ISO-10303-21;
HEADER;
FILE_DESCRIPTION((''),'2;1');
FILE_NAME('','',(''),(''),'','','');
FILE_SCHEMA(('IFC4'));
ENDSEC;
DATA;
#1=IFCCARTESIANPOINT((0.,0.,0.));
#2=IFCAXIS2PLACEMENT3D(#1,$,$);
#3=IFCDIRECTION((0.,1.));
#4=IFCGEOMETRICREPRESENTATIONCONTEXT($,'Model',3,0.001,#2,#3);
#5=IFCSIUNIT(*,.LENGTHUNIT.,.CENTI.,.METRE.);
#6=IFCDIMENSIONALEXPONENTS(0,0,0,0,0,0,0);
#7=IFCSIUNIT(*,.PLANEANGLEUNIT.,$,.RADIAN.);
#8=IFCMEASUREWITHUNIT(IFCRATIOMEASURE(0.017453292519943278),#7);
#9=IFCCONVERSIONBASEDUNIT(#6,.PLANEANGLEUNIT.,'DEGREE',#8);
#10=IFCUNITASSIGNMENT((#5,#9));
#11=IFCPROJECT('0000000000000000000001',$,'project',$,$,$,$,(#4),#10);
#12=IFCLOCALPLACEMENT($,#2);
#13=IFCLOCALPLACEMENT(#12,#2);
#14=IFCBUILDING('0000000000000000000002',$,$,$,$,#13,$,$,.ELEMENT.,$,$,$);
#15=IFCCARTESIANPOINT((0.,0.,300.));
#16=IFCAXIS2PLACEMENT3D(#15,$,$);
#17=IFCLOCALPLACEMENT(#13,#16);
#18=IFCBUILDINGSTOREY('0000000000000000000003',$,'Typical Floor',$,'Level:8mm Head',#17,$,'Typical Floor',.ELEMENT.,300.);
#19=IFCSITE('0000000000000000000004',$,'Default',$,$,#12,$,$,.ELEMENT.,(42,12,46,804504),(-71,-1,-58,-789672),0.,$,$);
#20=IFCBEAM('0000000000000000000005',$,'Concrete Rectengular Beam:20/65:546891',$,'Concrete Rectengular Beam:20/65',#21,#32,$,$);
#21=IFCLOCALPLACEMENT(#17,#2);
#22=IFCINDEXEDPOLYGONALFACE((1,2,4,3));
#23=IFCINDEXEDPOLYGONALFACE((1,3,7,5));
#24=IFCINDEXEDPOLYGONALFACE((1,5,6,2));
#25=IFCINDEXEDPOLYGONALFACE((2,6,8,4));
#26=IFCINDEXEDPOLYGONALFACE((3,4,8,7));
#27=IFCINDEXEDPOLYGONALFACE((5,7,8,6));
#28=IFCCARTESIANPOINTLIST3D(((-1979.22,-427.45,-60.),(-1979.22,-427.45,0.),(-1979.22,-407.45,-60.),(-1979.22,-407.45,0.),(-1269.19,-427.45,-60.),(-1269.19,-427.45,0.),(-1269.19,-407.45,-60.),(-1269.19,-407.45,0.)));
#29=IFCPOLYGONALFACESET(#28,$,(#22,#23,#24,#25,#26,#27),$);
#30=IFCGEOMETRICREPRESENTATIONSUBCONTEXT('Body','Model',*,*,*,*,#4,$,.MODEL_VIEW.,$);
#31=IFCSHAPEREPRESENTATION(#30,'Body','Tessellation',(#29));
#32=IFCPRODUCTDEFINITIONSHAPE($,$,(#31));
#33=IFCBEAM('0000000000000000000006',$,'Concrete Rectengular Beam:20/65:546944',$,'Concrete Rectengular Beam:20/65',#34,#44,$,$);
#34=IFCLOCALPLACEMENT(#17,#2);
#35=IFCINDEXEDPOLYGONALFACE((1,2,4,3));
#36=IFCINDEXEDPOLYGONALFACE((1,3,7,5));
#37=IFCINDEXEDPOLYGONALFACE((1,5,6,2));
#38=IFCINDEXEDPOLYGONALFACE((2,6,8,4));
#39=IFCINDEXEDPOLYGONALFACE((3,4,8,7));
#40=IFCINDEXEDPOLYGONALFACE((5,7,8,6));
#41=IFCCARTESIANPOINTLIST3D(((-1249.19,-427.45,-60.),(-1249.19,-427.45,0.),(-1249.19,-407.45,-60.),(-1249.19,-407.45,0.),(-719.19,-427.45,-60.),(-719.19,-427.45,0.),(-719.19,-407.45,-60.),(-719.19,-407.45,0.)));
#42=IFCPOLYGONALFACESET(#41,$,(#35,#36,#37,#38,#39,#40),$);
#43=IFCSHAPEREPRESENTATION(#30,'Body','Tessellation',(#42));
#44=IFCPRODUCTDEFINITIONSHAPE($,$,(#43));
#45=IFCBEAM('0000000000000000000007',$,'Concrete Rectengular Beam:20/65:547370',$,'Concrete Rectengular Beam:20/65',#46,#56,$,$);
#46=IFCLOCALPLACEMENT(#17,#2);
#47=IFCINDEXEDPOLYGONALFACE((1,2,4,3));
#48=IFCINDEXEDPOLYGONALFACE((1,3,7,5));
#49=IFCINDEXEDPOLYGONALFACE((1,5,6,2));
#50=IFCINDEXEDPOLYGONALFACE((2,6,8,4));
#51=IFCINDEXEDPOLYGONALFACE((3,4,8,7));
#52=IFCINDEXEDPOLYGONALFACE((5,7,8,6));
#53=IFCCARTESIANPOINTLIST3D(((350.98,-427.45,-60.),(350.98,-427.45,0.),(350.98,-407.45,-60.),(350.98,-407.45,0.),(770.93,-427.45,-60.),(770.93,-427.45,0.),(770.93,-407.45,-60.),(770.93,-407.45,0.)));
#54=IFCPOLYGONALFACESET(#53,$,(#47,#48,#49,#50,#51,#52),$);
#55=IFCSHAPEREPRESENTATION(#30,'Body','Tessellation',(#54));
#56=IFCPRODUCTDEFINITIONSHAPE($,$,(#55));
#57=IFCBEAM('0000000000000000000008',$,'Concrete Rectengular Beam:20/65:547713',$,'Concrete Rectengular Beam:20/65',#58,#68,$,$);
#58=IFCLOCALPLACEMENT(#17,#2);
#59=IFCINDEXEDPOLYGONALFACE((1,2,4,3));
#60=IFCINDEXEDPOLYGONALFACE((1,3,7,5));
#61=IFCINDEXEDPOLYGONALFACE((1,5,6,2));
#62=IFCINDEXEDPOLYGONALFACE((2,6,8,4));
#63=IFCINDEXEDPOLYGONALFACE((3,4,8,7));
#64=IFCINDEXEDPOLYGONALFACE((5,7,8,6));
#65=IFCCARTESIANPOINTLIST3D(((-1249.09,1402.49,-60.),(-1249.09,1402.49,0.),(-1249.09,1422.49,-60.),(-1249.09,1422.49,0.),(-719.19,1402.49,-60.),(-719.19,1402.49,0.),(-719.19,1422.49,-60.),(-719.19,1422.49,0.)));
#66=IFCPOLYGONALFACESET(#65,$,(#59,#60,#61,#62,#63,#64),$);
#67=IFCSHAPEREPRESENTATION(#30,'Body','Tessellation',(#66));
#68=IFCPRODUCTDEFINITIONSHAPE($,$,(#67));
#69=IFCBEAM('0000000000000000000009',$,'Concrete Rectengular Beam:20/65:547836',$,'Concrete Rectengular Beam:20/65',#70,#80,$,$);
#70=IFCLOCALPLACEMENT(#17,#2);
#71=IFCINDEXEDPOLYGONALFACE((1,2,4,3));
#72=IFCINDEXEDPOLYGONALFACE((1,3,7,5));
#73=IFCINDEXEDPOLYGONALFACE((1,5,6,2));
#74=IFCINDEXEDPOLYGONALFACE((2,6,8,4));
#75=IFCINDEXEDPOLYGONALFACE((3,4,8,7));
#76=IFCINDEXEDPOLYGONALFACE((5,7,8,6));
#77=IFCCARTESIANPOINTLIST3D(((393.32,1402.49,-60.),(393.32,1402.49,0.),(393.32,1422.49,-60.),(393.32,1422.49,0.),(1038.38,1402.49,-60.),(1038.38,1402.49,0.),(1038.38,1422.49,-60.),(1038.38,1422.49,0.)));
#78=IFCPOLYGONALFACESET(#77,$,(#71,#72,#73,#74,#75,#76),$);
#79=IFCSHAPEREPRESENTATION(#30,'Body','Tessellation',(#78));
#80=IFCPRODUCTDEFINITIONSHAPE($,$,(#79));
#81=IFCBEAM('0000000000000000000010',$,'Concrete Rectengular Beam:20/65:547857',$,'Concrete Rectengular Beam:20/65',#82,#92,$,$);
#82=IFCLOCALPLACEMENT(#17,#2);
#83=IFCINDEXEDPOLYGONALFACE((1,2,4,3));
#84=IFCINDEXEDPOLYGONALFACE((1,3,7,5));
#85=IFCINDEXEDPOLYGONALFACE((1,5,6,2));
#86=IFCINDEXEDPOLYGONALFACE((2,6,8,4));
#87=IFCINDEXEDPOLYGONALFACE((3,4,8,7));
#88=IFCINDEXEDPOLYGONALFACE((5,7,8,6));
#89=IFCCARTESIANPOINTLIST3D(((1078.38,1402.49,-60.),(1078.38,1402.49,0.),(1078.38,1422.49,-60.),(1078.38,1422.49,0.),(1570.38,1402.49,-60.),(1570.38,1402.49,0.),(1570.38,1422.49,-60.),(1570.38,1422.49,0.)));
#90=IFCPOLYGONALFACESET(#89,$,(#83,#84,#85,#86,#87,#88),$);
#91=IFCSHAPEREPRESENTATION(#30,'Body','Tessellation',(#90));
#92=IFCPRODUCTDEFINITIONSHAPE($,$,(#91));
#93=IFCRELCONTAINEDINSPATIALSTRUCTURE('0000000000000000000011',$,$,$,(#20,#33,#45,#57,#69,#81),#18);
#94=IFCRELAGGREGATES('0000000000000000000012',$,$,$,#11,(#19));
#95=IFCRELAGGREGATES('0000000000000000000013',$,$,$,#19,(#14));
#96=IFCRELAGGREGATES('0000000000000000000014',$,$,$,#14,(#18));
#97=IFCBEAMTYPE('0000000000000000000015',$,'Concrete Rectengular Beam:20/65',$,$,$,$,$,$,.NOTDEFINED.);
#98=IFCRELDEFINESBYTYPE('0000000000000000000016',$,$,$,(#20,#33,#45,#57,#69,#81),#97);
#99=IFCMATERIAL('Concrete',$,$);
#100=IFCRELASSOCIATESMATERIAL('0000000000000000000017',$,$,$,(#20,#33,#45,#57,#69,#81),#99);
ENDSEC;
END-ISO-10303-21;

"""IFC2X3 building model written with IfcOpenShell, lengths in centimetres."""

from ifc_helpers import new_model, entity, si_unit, converted_unit, direction, frame, frame_2d, origin, place, context, subcontext, project, spatial, rectangle, extrude, material, type_object, element, save


model = new_model("IFC2X3")

# Units and contexts
model_context = context("Model", 3, precision=0.001, world=origin(), true_north=direction((0.0, 1.0)))
body_context = subcontext(model_context, "Body", "Model", "MODEL_VIEW")
ifc_project = project(units=[si_unit("LENGTHUNIT", "METRE", prefix="CENTI"), converted_unit("PLANEANGLEUNIT", "DEGREE", entity("IfcRatioMeasure", 0.017453292519943278), si_unit("PLANEANGLEUNIT", "RADIAN"), dimensions=[0, 0, 0, 0, 0, 0, 0])], contexts=[model_context])

# Site, building, storey
site_placement = place(None, origin())
site = spatial("IfcSite", under=ifc_project, at=site_placement, Name="Default", CompositionType="ELEMENT", RefLatitude=(42, 12, 46, 804504), RefLongitude=(-71, -1, -58, -789672), RefElevation=0.0)
building_placement = place(site_placement, origin())
building = spatial("IfcBuilding", under=site, at=building_placement, CompositionType="ELEMENT")
storey_placement = place(building_placement, frame((0.0, 0.0, 300.0)))
storey = spatial("IfcBuildingStorey", under=building, at=storey_placement, Name="Typical Floor", ObjectType="Level:8mm Head", LongName="Typical Floor", CompositionType="ELEMENT", Elevation=300.0)

# Beams
ifc_material = material(Name="Concrete")
beam_type_1 = type_object("IfcBeamType", Name="Concrete Rectengular Beam:20/65", PredefinedType="NOTDEFINED")
beam_1_placement = place(storey_placement, frame((-1999.22, -417.45, 0.0)))
element("IfcBeam", 1, at=beam_1_placement, inside=storey, type_object=beam_type_1, material=ifc_material, Name="Concrete Rectengular Beam:20/65:546891", ObjectType="Concrete Rectengular Beam:20/65", context=body_context, shape_type="SweptSolid", body=[
    extrude(rectangle(XDim=60.0, YDim=20.0, at=frame_2d((0.0, 0.0), x_axis=(1.0, 0.0))), frame((20.0, 0.0, -30.0), z_axis=(1.0, 0.0, 0.0), x_axis=(0.0, 0.0, -1.0)), (0.0, 0.0, 1.0), 710.03),
])
beam_2_placement = place(storey_placement, frame((-1259.19, -417.45, 0.0)))
element("IfcBeam", 2, at=beam_2_placement, inside=storey, type_object=beam_type_1, material=ifc_material, Name="Concrete Rectengular Beam:20/65:546944", ObjectType="Concrete Rectengular Beam:20/65", context=body_context, shape_type="SweptSolid", body=[
    extrude(rectangle(XDim=60.0, YDim=20.0, at=frame_2d((0.0, 0.0), x_axis=(1.0, 0.0))), frame((10.0, 0.0, -30.0), z_axis=(1.0, 0.0, 0.0), x_axis=(0.0, 0.0, -1.0)), (0.0, 0.0, 1.0), 530.01),
])
beam_3_placement = place(storey_placement, frame((330.98, -417.45, 0.0)))
element("IfcBeam", 3, at=beam_3_placement, inside=storey, type_object=beam_type_1, material=ifc_material, Name="Concrete Rectengular Beam:20/65:547370", ObjectType="Concrete Rectengular Beam:20/65", context=body_context, shape_type="SweptSolid", body=[
    extrude(rectangle(XDim=60.0, YDim=20.0, at=frame_2d((0.0, 0.0), x_axis=(1.0, 0.0))), frame((20.0, 0.0, -30.0), z_axis=(1.0, 0.0, 0.0), x_axis=(0.0, 0.0, -1.0)), (0.0, 0.0, 1.0), 419.95),
])
beam_4_placement = place(storey_placement, frame((-1259.09, 1412.49, 0.0)))
element("IfcBeam", 4, at=beam_4_placement, inside=storey, type_object=beam_type_1, material=ifc_material, Name="Concrete Rectengular Beam:20/65:547713", ObjectType="Concrete Rectengular Beam:20/65", context=body_context, shape_type="SweptSolid", body=[
    extrude(rectangle(XDim=60.0, YDim=20.0, at=frame_2d((0.0, 0.0), x_axis=(1.0, 0.0))), frame((10.0, 0.0, -30.0), z_axis=(1.0, 0.0, 0.0), x_axis=(0.0, 0.0, -1.0)), (0.0, 0.0, 1.0), 529.9),
])
beam_5_placement = place(storey_placement, frame((383.32, 1412.49, 0.0)))
element("IfcBeam", 5, at=beam_5_placement, inside=storey, type_object=beam_type_1, material=ifc_material, Name="Concrete Rectengular Beam:20/65:547836", ObjectType="Concrete Rectengular Beam:20/65", context=body_context, shape_type="SweptSolid", body=[
    extrude(rectangle(XDim=60.0, YDim=20.0, at=frame_2d((0.0, 0.0), x_axis=(1.0, 0.0))), frame((10.0, 0.0, -30.0), z_axis=(1.0, 0.0, 0.0), x_axis=(0.0, 0.0, -1.0)), (0.0, 0.0, 1.0), 645.06),
])
beam_6_placement = place(storey_placement, frame((1058.38, 1412.49, 0.0)))
element("IfcBeam", 6, at=beam_6_placement, inside=storey, type_object=beam_type_1, material=ifc_material, Name="Concrete Rectengular Beam:20/65:547857", ObjectType="Concrete Rectengular Beam:20/65", context=body_context, shape_type="SweptSolid", body=[
    extrude(rectangle(XDim=60.0, YDim=20.0, at=frame_2d((0.0, 0.0), x_axis=(1.0, 0.0))), frame((20.0, 0.0, -30.0), z_axis=(1.0, 0.0, 0.0), x_axis=(0.0, 0.0, -1.0)), (0.0, 0.0, 1.0), 492.0),
])

save(model, "model.ifc")
